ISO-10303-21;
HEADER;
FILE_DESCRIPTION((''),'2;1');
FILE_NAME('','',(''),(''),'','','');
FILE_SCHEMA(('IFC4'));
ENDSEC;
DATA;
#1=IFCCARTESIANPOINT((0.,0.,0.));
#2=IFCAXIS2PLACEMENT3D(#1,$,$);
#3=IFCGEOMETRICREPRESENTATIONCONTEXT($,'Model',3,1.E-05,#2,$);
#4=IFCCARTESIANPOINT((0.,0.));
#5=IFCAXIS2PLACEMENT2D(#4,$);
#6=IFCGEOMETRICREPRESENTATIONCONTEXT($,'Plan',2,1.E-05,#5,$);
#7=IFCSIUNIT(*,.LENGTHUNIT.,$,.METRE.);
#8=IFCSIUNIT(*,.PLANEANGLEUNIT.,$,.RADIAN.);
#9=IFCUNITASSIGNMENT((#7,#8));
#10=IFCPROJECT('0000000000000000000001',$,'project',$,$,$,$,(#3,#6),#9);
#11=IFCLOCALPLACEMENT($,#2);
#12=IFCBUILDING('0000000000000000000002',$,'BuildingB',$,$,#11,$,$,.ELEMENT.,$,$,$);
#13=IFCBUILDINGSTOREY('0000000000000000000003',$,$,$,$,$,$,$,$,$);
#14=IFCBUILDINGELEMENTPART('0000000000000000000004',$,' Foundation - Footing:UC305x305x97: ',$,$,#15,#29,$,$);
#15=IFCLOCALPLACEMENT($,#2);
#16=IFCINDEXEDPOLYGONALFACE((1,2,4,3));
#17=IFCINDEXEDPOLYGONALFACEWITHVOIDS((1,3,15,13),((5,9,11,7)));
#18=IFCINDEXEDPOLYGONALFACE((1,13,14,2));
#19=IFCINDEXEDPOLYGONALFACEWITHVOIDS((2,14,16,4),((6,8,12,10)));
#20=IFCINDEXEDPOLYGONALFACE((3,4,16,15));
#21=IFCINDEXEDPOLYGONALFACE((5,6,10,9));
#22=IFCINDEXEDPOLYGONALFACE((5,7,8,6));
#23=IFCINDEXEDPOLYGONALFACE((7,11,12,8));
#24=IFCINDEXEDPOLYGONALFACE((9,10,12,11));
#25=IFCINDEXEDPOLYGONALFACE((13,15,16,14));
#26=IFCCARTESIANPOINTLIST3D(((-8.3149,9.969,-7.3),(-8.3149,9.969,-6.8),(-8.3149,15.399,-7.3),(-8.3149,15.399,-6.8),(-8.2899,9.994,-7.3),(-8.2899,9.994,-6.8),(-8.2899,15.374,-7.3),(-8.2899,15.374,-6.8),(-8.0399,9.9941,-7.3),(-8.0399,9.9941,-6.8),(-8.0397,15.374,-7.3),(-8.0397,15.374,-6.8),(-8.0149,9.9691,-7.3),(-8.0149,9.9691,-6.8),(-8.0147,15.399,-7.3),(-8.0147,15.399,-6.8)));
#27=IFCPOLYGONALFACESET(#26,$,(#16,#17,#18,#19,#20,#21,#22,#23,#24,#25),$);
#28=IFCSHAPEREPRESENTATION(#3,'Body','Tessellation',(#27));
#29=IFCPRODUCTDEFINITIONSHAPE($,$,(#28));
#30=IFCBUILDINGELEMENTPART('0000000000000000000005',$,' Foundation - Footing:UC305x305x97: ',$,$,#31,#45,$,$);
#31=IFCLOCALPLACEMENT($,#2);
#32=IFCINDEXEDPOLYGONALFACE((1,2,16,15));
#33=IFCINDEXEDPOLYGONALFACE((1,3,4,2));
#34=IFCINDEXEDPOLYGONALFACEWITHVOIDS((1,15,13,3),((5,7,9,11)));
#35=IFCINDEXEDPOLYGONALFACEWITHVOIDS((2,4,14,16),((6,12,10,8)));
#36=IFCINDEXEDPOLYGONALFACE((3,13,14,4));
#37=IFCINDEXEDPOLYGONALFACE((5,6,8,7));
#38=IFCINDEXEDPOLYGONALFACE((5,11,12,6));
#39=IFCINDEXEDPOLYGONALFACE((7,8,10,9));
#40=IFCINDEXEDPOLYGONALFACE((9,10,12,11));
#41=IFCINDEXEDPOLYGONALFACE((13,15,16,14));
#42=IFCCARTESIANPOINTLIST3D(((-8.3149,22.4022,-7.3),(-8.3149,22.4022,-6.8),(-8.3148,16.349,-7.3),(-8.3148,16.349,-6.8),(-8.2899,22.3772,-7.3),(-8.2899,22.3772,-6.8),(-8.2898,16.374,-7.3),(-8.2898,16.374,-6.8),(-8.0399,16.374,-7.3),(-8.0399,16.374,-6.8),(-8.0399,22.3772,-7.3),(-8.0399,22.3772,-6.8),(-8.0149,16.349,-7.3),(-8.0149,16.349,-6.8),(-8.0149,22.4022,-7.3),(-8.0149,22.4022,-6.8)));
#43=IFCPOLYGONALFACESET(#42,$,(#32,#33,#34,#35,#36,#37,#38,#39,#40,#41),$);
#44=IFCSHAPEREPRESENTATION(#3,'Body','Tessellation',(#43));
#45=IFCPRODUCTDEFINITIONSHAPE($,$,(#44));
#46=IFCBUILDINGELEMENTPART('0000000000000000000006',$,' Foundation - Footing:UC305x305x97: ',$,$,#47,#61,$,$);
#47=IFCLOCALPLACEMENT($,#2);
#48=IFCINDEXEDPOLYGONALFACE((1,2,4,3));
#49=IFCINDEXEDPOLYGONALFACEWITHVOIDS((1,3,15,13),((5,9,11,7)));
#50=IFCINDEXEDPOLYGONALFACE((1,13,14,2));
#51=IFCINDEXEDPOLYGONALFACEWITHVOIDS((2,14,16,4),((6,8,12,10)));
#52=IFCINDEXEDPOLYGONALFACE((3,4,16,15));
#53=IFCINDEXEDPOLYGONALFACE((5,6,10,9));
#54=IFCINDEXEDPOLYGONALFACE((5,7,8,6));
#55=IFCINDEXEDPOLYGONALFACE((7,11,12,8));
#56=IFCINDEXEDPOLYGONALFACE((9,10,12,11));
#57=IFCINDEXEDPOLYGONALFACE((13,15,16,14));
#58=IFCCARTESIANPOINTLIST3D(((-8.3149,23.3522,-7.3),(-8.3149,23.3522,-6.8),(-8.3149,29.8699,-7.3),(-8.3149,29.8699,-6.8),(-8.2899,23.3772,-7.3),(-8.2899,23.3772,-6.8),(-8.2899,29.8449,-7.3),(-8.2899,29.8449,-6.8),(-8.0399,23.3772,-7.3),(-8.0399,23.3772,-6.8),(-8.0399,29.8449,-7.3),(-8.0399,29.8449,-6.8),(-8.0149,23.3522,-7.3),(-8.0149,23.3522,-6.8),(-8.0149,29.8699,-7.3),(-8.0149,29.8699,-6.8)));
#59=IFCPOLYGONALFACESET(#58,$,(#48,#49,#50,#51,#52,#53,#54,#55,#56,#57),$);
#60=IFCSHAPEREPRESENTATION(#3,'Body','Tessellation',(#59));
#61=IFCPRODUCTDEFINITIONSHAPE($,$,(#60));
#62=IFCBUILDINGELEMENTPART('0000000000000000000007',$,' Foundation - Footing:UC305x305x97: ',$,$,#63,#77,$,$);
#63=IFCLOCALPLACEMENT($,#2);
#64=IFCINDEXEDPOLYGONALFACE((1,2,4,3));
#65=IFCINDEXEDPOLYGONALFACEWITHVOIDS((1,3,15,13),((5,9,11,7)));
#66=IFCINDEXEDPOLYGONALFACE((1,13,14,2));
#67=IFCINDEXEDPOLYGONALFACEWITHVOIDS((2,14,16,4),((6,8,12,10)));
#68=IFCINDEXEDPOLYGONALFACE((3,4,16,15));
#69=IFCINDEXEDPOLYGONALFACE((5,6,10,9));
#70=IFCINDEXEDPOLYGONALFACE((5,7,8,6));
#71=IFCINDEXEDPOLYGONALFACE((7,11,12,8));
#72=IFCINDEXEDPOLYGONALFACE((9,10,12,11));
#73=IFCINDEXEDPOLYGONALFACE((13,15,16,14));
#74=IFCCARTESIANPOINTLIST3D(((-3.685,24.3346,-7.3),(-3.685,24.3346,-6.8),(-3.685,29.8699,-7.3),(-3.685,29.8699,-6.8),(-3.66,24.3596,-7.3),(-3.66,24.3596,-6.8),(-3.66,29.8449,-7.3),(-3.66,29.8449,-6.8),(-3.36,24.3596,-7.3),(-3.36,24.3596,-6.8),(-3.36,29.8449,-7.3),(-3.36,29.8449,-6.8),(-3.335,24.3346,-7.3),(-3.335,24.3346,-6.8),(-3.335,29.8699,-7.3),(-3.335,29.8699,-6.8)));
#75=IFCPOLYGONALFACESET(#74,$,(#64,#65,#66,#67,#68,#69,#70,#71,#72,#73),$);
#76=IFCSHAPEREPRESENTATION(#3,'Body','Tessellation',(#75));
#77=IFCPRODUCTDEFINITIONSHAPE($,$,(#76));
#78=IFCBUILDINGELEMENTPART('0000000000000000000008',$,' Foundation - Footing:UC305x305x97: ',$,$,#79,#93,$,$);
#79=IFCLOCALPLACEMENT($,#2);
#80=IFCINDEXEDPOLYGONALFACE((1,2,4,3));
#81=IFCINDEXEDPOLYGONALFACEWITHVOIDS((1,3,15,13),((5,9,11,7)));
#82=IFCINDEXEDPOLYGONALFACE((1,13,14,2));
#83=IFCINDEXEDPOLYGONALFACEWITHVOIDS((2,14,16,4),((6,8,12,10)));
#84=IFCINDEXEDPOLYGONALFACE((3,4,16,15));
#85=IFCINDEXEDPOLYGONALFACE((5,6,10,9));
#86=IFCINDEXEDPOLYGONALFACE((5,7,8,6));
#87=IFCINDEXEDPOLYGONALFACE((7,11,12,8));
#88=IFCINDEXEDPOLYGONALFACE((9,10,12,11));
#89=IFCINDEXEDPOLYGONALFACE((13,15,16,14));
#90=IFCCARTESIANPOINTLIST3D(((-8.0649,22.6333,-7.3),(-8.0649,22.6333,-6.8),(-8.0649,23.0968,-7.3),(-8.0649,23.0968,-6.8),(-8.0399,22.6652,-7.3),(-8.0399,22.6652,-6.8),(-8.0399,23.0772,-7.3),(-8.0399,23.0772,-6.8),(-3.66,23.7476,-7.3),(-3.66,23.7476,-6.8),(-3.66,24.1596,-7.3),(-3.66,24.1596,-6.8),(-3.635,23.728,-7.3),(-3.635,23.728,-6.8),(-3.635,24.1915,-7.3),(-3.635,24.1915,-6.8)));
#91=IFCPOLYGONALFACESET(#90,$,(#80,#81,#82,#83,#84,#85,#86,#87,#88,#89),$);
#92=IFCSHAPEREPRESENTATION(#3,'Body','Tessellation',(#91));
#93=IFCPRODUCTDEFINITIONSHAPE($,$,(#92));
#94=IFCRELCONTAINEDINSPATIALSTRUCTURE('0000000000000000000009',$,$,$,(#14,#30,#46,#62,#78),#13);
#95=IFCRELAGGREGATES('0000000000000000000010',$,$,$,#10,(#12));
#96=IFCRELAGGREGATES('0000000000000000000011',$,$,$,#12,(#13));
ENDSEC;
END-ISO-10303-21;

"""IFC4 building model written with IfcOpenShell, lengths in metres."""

from ifc_helpers import new_model, si_unit, origin, origin_2d, place, context, project, spatial, polyline, outline, extrude, element, save


model = new_model("IFC4")

# Units and contexts
model_context = context("Model", 3, precision=1e-05, world=origin())
plan_context = context("Plan", 2, precision=1e-05, world=origin_2d())
ifc_project = project(units=[si_unit("LENGTHUNIT", "METRE"), si_unit("PLANEANGLEUNIT", "RADIAN")], contexts=[model_context, plan_context])

# Building, storey
building_placement = place(None, origin())
building = spatial("IfcBuilding", under=ifc_project, at=building_placement, Name="BuildingB", CompositionType="ELEMENT")
storey = spatial("IfcBuildingStorey", under=building)

# Building element parts, openings
building_element_part_1 = element("IfcBuildingElementPart", 1, inside=storey, Name=" Foundation - Footing:UC305x305x97: ", context=model_context, shape_type="SweptSolid", body=[
    extrude(outline(polyline([(-8.3149, 9.969, -7.3), (-8.0149, 9.9691, -7.3), (-8.0147, 15.399, -7.3), (-8.3149, 15.399, -7.3), (-8.3149, 9.969, -7.3)])), None, (0.0, 0.0, 1.0), 0.5),
])
element("IfcOpeningElement", 2, inside=storey, cuts=building_element_part_1, context=model_context, shape_type="SweptSolid", body=[
    extrude(outline(polyline([(-8.2899, 9.994, -7.3), (-8.0399, 9.9941, -7.3), (-8.0397, 15.374, -7.3), (-8.2899, 15.374, -7.3), (-8.2899, 9.994, -7.3)])), None, (0.0, 0.0, 1.0), 0.5),
])
building_element_part_2 = element("IfcBuildingElementPart", 3, inside=storey, Name=" Foundation - Footing:UC305x305x97: ", context=model_context, shape_type="SweptSolid", body=[
    extrude(outline(polyline([(-8.3148, 16.349, -7.3), (-8.0149, 16.349, -7.3), (-8.0149, 22.4022, -7.3), (-8.3149, 22.4022, -7.3), (-8.3148, 16.349, -7.3)])), None, (0.0, 0.0, 1.0), 0.5),
])
element("IfcOpeningElement", 4, inside=storey, cuts=building_element_part_2, context=model_context, shape_type="SweptSolid", body=[
    extrude(outline(polyline([(-8.2898, 16.374, -7.3), (-8.0399, 16.374, -7.3), (-8.0399, 22.3772, -7.3), (-8.2899, 22.3772, -7.3), (-8.2898, 16.374, -7.3)])), None, (0.0, 0.0, 1.0), 0.5),
])
building_element_part_3 = element("IfcBuildingElementPart", 5, inside=storey, Name=" Foundation - Footing:UC305x305x97: ", context=model_context, shape_type="SweptSolid", body=[
    extrude(outline(polyline([(-8.3149, 23.3522, -7.3), (-8.0149, 23.3522, -7.3), (-8.0149, 29.8699, -7.3), (-8.3149, 29.8699, -7.3), (-8.3149, 23.3522, -7.3)])), None, (0.0, 0.0, 1.0), 0.5),
])
element("IfcOpeningElement", 6, inside=storey, cuts=building_element_part_3, context=model_context, shape_type="SweptSolid", body=[
    extrude(outline(polyline([(-8.2899, 23.3772, -7.3), (-8.0399, 23.3772, -7.3), (-8.0399, 29.8449, -7.3), (-8.2899, 29.8449, -7.3), (-8.2899, 23.3772, -7.3)])), None, (0.0, 0.0, 1.0), 0.5),
])
building_element_part_4 = element("IfcBuildingElementPart", 7, inside=storey, Name=" Foundation - Footing:UC305x305x97: ", context=model_context, shape_type="SweptSolid", body=[
    extrude(outline(polyline([(-3.685, 29.8699, -7.3), (-3.335, 29.8699, -7.3), (-3.335, 24.3346, -7.3), (-3.685, 24.3346, -7.3), (-3.685, 29.8699, -7.3)])), None, (0.0, 0.0, 1.0), 0.5),
])
element("IfcOpeningElement", 8, inside=storey, cuts=building_element_part_4, context=model_context, shape_type="SweptSolid", body=[
    extrude(outline(polyline([(-3.66, 29.8449, -7.3), (-3.36, 29.8449, -7.3), (-3.36, 24.3596, -7.3), (-3.66, 24.3596, -7.3), (-3.66, 29.8449, -7.3)])), None, (0.0, 0.0, 1.0), 0.5),
])
building_element_part_5 = element("IfcBuildingElementPart", 9, inside=storey, Name=" Foundation - Footing:UC305x305x97: ", context=model_context, shape_type="SweptSolid", body=[
    extrude(outline(polyline([(-3.635, 24.1915, -7.3), (-3.635, 23.728, -7.3), (-8.0649, 22.6333, -7.3), (-8.0649, 23.0968, -7.3), (-3.635, 24.1915, -7.3)])), None, (0.0, 0.0, 1.0), 0.5),
])
element("IfcOpeningElement", 10, inside=storey, cuts=building_element_part_5, context=model_context, shape_type="SweptSolid", body=[
    extrude(outline(polyline([(-3.66, 24.1596, -7.3), (-3.66, 23.7476, -7.3), (-8.0399, 22.6652, -7.3), (-8.0399, 23.0772, -7.3), (-3.66, 24.1596, -7.3)])), None, (0.0, 0.0, 1.0), 0.5),
])

save(model, "model.ifc")
